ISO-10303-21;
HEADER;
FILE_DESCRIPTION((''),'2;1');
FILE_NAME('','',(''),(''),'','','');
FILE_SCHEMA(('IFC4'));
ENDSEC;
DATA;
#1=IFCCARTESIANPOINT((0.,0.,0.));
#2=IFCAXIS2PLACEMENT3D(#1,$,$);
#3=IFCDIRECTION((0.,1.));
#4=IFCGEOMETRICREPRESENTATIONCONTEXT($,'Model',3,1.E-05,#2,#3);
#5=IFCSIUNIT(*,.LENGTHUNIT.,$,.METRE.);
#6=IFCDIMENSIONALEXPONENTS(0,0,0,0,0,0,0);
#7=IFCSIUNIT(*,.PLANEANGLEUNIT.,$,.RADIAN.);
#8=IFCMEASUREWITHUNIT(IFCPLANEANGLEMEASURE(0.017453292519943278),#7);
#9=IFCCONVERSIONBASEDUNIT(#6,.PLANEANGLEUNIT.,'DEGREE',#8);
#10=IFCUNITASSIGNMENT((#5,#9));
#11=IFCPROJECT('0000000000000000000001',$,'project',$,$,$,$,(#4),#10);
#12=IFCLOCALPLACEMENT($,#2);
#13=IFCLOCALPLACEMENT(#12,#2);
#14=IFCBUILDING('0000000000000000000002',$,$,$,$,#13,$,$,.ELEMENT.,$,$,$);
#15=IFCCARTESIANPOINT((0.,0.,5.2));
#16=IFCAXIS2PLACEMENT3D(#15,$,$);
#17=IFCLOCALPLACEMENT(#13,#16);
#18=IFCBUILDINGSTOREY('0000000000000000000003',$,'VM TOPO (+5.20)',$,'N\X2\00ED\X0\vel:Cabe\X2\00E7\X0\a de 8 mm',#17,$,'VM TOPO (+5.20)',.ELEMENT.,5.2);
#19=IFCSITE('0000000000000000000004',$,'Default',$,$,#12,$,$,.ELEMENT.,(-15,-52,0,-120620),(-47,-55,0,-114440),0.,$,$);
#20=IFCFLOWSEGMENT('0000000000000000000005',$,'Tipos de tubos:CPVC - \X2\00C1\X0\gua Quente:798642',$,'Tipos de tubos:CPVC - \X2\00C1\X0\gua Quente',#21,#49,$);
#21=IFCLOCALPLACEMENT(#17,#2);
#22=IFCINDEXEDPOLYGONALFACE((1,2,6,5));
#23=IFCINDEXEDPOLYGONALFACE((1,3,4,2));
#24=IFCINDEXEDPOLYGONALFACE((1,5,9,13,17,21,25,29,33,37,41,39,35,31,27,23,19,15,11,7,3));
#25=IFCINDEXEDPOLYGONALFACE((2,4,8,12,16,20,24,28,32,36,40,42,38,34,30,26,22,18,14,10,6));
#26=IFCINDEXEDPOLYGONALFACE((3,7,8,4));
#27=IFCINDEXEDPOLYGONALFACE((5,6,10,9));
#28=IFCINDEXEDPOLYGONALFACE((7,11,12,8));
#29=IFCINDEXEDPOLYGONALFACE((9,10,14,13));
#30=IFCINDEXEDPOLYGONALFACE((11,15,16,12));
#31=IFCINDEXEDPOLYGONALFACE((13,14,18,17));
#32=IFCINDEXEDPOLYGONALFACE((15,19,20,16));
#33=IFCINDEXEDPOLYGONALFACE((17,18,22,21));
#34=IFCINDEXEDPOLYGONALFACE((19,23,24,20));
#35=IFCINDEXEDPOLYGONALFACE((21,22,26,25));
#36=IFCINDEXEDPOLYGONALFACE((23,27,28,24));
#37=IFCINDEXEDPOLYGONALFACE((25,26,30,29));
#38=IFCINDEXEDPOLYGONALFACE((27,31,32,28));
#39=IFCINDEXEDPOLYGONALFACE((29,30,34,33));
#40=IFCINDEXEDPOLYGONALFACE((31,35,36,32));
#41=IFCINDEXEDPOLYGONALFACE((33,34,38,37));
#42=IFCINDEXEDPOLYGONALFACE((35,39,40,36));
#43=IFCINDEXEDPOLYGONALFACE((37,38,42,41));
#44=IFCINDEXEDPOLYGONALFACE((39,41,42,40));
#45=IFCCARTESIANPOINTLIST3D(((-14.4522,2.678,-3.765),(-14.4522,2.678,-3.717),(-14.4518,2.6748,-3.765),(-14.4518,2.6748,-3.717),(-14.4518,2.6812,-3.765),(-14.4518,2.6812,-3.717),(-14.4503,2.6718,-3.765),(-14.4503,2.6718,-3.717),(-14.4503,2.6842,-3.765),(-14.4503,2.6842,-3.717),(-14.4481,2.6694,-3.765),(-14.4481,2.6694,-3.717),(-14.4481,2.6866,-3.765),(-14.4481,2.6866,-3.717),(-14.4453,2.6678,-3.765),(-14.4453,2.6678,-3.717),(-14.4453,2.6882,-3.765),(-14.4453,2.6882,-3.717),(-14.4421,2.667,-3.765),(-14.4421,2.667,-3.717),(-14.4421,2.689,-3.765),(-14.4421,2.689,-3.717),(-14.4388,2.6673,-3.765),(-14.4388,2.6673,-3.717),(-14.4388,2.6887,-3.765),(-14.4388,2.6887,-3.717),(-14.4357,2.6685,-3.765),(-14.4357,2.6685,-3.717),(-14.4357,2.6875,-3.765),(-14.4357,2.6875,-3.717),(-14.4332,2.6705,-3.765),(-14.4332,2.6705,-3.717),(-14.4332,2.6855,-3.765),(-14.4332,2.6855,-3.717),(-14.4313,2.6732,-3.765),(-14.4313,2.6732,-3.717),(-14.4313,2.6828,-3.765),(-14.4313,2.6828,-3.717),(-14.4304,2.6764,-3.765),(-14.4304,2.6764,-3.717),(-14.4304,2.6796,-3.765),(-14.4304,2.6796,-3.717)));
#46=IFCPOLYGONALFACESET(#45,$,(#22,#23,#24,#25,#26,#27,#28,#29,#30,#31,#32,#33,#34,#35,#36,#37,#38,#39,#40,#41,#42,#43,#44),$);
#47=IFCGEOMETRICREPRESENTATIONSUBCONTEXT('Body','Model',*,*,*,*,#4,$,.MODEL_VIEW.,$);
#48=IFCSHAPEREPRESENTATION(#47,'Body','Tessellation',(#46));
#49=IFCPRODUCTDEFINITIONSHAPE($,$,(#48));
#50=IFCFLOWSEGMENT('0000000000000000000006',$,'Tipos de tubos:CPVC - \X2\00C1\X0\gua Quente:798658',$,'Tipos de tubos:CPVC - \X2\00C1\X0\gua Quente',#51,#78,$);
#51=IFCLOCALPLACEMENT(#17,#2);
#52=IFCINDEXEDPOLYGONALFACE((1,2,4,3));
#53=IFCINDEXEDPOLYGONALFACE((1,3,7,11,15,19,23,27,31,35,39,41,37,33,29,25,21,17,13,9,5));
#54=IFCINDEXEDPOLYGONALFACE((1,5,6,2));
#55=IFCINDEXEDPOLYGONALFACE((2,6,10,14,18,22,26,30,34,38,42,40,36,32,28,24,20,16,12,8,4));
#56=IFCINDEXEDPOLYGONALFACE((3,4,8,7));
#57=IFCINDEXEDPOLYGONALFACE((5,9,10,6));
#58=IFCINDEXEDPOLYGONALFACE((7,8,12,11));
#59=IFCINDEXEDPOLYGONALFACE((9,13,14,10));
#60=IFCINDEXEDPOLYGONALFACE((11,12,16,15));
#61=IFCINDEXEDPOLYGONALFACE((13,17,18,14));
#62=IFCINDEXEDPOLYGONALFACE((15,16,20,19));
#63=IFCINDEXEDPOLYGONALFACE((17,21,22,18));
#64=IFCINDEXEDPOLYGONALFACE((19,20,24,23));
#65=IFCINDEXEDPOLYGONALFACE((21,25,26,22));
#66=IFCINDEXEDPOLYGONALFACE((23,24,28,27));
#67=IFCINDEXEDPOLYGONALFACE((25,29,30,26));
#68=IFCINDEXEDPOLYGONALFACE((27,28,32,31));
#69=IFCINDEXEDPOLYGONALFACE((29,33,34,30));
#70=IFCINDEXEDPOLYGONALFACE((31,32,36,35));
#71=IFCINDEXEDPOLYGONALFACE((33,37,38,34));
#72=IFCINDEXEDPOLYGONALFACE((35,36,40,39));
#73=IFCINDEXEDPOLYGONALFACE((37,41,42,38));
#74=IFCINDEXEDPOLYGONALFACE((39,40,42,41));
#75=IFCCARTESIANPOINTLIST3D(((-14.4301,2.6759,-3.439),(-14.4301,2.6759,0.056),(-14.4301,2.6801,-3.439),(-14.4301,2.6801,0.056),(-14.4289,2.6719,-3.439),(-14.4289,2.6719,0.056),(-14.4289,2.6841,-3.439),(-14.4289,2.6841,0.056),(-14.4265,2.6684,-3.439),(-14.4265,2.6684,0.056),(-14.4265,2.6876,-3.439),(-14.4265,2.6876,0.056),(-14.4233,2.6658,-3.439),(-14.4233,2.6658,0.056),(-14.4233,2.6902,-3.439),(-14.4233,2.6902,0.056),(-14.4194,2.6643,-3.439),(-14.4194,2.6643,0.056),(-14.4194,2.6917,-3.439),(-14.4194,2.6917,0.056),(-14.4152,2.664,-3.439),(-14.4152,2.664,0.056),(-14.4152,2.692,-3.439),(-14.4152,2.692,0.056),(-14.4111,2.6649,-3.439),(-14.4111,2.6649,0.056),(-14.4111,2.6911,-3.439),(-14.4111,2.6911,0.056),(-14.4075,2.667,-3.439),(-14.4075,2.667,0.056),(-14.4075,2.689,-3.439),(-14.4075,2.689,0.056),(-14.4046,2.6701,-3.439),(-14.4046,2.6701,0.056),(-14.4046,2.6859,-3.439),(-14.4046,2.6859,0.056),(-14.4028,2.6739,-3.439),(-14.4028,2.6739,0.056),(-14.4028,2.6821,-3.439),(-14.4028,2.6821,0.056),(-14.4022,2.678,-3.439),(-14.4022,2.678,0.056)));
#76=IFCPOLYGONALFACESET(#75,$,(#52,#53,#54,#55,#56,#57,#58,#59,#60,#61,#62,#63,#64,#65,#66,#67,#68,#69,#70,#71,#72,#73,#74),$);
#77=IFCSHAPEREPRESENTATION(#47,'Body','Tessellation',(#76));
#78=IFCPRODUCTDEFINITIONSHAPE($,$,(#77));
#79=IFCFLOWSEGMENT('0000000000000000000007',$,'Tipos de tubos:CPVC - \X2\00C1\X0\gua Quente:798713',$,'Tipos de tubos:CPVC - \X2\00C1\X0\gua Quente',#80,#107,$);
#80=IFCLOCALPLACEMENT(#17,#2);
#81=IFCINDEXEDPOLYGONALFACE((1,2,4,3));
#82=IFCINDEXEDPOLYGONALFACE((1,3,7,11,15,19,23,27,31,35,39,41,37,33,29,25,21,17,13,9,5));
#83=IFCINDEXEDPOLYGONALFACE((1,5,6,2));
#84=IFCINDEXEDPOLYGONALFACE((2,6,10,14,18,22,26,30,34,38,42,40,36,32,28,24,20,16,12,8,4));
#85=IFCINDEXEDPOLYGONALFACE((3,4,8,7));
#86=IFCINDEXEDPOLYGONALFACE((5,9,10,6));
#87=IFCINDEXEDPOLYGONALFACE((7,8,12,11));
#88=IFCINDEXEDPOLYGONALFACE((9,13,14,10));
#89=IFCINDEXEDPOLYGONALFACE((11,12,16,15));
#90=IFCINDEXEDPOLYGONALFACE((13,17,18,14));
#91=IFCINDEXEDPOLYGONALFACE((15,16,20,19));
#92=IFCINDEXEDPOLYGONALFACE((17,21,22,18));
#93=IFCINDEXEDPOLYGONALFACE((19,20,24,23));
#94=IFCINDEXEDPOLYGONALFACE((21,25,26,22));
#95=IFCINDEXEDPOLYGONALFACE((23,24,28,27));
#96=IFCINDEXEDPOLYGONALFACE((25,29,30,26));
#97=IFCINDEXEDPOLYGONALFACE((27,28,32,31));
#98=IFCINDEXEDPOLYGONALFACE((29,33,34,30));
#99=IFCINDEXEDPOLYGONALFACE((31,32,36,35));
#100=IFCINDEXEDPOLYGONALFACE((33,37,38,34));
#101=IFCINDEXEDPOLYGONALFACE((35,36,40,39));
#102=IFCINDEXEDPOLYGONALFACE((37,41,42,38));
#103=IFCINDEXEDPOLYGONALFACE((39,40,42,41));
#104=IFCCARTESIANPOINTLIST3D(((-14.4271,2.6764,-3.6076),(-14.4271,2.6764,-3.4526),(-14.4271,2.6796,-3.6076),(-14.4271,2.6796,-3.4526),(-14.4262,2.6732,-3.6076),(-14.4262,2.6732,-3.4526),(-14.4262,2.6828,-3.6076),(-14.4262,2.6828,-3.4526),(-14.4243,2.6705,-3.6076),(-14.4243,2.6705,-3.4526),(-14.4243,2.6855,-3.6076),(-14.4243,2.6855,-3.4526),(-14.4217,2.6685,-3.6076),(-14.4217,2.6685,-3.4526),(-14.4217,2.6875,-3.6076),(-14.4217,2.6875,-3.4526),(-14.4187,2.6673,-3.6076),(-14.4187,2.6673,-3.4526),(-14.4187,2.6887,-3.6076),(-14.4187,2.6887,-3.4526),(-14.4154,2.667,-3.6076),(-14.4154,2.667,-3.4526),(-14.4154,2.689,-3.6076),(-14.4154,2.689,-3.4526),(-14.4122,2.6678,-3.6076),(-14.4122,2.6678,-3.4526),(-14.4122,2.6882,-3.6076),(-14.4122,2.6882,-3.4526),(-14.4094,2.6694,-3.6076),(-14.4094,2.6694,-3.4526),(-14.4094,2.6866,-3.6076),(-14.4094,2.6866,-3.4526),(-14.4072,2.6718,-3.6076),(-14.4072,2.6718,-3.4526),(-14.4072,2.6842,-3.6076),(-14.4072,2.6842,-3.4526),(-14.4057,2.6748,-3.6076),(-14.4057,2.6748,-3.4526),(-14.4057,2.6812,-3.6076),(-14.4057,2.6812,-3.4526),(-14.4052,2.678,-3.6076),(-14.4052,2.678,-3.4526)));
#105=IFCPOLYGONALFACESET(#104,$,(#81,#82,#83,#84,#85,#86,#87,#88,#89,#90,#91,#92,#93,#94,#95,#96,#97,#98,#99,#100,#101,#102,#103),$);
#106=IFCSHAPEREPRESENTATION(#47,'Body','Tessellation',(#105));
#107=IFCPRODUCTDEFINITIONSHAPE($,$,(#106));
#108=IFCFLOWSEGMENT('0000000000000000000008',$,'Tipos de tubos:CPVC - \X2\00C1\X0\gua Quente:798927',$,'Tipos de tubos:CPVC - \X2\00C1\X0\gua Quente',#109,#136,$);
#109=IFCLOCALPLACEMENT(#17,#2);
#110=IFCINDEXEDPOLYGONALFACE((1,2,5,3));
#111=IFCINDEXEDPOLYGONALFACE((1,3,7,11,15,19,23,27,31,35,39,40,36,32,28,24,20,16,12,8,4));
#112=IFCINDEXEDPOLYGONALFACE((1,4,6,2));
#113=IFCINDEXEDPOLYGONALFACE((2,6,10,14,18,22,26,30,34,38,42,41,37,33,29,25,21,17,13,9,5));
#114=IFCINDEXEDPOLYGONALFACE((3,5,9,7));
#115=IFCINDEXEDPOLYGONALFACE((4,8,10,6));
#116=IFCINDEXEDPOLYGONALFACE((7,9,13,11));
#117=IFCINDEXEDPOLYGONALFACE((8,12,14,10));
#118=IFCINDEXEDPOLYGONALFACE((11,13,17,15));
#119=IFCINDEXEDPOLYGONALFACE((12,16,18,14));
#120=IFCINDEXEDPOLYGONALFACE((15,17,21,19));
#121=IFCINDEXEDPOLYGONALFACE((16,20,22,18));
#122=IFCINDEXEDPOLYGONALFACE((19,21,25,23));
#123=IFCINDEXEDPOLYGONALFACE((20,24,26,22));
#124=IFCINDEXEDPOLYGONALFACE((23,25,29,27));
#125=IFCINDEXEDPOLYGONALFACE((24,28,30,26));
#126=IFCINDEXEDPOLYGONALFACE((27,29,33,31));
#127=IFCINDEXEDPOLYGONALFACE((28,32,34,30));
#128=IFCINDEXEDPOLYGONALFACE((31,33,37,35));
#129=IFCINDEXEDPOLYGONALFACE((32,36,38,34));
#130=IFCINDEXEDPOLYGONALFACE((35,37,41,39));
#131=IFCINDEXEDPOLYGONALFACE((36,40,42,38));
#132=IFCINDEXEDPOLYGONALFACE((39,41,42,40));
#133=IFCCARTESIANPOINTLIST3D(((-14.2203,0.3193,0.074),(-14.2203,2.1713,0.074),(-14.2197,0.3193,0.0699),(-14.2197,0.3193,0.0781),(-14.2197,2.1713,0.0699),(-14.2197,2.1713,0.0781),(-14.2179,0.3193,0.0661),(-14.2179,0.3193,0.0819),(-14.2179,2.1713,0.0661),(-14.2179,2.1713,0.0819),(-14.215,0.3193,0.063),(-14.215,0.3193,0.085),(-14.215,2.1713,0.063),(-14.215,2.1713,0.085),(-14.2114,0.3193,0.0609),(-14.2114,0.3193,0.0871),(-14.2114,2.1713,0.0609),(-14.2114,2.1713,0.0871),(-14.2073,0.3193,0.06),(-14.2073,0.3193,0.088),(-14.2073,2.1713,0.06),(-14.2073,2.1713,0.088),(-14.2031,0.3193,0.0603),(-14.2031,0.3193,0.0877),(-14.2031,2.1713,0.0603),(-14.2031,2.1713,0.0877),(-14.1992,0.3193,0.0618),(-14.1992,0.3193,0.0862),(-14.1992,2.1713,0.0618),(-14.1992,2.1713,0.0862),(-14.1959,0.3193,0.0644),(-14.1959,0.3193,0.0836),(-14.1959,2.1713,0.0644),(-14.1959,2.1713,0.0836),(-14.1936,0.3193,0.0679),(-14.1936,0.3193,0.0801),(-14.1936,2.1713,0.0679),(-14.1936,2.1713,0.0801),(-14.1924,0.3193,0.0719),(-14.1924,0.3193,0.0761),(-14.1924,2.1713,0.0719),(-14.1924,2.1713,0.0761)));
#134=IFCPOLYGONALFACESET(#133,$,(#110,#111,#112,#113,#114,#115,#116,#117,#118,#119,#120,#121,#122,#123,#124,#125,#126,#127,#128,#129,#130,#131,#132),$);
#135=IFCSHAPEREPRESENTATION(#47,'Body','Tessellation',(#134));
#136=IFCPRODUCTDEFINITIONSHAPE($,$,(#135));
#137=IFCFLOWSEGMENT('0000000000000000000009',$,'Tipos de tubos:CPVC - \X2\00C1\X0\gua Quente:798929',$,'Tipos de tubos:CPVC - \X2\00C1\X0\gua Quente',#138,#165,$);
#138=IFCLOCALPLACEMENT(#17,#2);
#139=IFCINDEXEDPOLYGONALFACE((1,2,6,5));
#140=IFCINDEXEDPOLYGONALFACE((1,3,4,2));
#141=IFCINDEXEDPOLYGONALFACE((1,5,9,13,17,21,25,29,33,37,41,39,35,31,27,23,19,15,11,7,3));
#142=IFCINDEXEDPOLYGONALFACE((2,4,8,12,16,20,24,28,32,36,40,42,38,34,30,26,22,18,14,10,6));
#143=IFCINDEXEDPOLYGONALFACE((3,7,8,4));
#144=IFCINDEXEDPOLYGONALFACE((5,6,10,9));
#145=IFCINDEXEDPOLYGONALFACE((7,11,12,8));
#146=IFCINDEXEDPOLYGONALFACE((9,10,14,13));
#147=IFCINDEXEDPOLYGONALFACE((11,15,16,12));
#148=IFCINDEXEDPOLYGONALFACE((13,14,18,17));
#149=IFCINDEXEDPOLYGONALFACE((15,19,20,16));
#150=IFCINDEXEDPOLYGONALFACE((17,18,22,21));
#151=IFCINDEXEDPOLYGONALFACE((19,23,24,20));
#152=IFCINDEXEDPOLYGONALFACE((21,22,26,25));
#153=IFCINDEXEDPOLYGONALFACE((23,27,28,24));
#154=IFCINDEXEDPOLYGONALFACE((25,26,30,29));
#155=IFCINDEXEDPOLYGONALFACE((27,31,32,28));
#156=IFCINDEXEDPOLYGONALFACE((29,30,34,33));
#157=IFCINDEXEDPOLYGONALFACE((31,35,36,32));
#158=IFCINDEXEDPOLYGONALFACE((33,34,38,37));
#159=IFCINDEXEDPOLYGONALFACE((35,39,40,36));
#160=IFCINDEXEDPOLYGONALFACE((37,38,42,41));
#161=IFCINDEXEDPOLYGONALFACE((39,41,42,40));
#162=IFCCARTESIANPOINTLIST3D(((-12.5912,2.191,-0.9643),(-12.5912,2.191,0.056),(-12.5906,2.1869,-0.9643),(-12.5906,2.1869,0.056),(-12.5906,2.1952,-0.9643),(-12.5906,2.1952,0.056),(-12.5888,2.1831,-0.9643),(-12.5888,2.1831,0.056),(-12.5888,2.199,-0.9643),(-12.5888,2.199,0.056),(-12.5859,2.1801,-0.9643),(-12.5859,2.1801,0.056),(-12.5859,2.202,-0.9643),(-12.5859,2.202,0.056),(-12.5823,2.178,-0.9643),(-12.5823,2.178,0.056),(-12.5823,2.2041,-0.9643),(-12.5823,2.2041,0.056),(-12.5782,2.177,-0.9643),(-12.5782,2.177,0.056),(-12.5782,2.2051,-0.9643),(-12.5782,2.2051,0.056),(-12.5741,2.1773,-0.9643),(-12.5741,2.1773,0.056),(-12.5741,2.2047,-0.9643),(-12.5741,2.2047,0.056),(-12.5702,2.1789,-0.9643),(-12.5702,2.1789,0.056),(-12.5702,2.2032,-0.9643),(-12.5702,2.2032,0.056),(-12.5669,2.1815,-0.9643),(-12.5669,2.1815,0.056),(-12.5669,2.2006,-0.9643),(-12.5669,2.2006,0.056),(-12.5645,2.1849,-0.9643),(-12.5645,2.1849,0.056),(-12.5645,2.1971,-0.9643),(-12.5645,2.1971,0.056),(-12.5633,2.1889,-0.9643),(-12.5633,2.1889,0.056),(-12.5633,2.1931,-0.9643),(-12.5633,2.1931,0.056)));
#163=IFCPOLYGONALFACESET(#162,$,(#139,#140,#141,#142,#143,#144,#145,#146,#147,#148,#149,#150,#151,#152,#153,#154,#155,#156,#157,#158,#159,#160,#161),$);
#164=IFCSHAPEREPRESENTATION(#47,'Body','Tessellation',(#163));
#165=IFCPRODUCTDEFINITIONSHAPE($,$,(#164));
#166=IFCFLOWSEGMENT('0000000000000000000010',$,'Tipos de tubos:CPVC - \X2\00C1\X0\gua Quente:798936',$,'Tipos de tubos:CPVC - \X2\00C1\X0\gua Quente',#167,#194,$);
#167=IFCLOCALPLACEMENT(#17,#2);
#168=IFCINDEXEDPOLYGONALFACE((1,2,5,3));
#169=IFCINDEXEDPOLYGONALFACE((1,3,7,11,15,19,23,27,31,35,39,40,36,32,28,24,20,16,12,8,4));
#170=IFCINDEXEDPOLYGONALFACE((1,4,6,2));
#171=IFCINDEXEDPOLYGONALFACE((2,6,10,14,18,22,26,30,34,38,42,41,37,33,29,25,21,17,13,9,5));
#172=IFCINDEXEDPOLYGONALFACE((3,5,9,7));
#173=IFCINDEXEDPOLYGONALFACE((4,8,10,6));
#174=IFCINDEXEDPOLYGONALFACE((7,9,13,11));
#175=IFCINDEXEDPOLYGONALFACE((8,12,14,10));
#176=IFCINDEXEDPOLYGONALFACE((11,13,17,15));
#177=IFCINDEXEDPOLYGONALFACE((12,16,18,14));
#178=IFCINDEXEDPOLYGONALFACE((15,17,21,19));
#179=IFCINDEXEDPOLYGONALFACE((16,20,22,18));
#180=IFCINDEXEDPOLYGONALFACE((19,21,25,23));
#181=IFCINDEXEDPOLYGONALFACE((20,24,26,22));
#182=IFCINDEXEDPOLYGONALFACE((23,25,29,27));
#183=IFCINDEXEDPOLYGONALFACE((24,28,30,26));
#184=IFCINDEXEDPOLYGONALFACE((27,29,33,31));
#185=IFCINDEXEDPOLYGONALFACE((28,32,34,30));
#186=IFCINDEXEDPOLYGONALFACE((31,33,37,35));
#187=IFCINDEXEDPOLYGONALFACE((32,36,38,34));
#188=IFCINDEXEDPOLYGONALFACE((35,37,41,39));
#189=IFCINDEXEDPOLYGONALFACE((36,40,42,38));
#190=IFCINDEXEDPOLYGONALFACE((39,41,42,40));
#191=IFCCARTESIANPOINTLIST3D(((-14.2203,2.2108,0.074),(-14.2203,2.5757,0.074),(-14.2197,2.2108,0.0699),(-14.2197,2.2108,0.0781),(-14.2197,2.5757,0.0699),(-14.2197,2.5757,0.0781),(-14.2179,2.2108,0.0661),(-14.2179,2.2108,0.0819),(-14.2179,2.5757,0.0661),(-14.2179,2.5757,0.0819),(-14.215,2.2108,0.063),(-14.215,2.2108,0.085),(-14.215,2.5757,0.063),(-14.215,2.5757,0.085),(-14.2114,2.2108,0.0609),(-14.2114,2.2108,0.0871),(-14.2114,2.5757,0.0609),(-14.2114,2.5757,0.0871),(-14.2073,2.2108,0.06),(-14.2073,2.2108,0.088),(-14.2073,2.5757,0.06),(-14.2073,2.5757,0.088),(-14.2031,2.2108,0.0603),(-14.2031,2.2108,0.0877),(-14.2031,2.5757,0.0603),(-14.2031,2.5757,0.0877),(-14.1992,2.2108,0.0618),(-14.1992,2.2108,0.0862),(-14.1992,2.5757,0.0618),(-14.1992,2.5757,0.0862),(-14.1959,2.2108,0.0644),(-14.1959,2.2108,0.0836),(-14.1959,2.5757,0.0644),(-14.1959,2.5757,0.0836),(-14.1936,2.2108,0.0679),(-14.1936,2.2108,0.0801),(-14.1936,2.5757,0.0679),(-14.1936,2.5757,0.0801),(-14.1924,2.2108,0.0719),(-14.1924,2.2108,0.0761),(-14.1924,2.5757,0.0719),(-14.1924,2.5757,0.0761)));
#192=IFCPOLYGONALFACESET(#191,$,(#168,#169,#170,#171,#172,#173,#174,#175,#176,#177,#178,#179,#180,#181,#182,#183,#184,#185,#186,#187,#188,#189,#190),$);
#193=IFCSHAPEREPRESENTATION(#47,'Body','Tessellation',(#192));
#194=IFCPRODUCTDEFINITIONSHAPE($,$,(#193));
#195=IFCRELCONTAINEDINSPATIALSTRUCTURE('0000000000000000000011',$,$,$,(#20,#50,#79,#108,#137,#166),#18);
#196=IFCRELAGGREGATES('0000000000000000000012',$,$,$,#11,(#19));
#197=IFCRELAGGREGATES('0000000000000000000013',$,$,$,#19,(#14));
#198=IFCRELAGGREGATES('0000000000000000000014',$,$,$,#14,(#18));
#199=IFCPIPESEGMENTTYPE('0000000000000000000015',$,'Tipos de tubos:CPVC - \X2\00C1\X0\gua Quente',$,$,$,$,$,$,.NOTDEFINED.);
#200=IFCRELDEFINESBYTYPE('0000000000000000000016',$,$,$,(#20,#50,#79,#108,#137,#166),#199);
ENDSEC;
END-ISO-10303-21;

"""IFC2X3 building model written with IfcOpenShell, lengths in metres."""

from ifc_helpers import new_model, entity, si_unit, converted_unit, direction, frame, frame_2d, origin, origin_2d_with_axis, place, context, subcontext, project, spatial, circle, extrude, type_object, element, save


model = new_model("IFC2X3")

# Units and contexts
model_context = context("Model", 3, precision=1e-05, world=origin(), true_north=direction((0.0, 1.0)))
body_context = subcontext(model_context, "Body", "Model", "MODEL_VIEW")
ifc_project = project(units=[si_unit("LENGTHUNIT", "METRE"), converted_unit("PLANEANGLEUNIT", "DEGREE", entity("IfcPlaneAngleMeasure", 0.017453292519943278), si_unit("PLANEANGLEUNIT", "RADIAN"), dimensions=[0, 0, 0, 0, 0, 0, 0])], contexts=[model_context])

# Site, building, storey
site_placement = place(None, origin())
site = spatial("IfcSite", under=ifc_project, at=site_placement, Name="Default", CompositionType="ELEMENT", RefLatitude=(-15, -52, 0, -120620), RefLongitude=(-47, -55, 0, -114440), RefElevation=0.0)
building_placement = place(site_placement, origin())
building = spatial("IfcBuilding", under=site, at=building_placement, CompositionType="ELEMENT")
storey_placement = place(building_placement, frame((0.0, 0.0, 5.2)))
storey = spatial("IfcBuildingStorey", under=building, at=storey_placement, Name="VM TOPO (+5.20)", ObjectType="Nível:Cabeça de 8 mm", LongName="VM TOPO (+5.20)", CompositionType="ELEMENT", Elevation=5.2)

# Flow segments
pipe_segment_type_1 = type_object("IfcPipeSegmentType", Name="Tipos de tubos:CPVC - Água Quente", PredefinedType="NOTDEFINED")
flow_segment_1_placement = place(storey_placement, origin())
element("IfcFlowSegment", 1, at=flow_segment_1_placement, inside=storey, type_object=pipe_segment_type_1, Name="Tipos de tubos:CPVC - Água Quente:798642", ObjectType="Tipos de tubos:CPVC - Água Quente", context=body_context, shape_type="SweptSolid", body=[
    extrude(circle(Radius=0.011, at=frame_2d((0.0, 0.0), x_axis=(1.0, 0.0))), frame((-14.4412, 2.678, -3.765), z_axis=(0.0, 0.0, 1.0), x_axis=(-1.0, 0.0, 0.0)), (0.0, 0.0, 1.0), 0.048),
])
flow_segment_2_placement = place(storey_placement, origin())
element("IfcFlowSegment", 2, at=flow_segment_2_placement, inside=storey, type_object=pipe_segment_type_1, Name="Tipos de tubos:CPVC - Água Quente:798658", ObjectType="Tipos de tubos:CPVC - Água Quente", context=body_context, shape_type="SweptSolid", body=[
    extrude(circle(Radius=0.0141, at=origin_2d_with_axis()), frame((-14.4162, 2.678, -3.439)), (0.0, 0.0, 1.0), 3.495),
])
flow_segment_3_placement = place(storey_placement, origin())
element("IfcFlowSegment", 3, at=flow_segment_3_placement, inside=storey, type_object=pipe_segment_type_1, Name="Tipos de tubos:CPVC - Água Quente:798713", ObjectType="Tipos de tubos:CPVC - Água Quente", context=body_context, shape_type="SweptSolid", body=[
    extrude(circle(Radius=0.011, at=frame_2d((0.0, 0.0), x_axis=(1.0, 0.0))), frame((-14.4162, 2.678, -3.6076)), (0.0, 0.0, 1.0), 0.155),
])
flow_segment_4_placement = place(storey_placement, origin())
element("IfcFlowSegment", 4, at=flow_segment_4_placement, inside=storey, type_object=pipe_segment_type_1, Name="Tipos de tubos:CPVC - Água Quente:798927", ObjectType="Tipos de tubos:CPVC - Água Quente", context=body_context, shape_type="SweptSolid", body=[
    extrude(circle(Radius=0.0141, at=frame_2d((0.0, 0.0), x_axis=(1.0, 0.0))), frame((-14.2062, 0.3193, 0.074), z_axis=(0.0, 1.0, 0.0), x_axis=(-1.0, 0.0, 0.0)), (0.0, 0.0, 1.0), 1.852),
])
flow_segment_5_placement = place(storey_placement, origin())
element("IfcFlowSegment", 5, at=flow_segment_5_placement, inside=storey, type_object=pipe_segment_type_1, Name="Tipos de tubos:CPVC - Água Quente:798929", ObjectType="Tipos de tubos:CPVC - Água Quente", context=body_context, shape_type="SweptSolid", body=[
    extrude(circle(Radius=0.0141, at=origin_2d_with_axis()), frame((-12.5772, 2.191, -0.9643), z_axis=(0.0, 0.0, 1.0), x_axis=(-1.0, 0.0, 0.0)), (0.0, 0.0, 1.0), 1.0203),
])
flow_segment_6_placement = place(storey_placement, origin())
element("IfcFlowSegment", 6, at=flow_segment_6_placement, inside=storey, type_object=pipe_segment_type_1, Name="Tipos de tubos:CPVC - Água Quente:798936", ObjectType="Tipos de tubos:CPVC - Água Quente", context=body_context, shape_type="SweptSolid", body=[
    extrude(circle(Radius=0.0141, at=frame_2d((0.0, 0.0), x_axis=(1.0, 0.0))), frame((-14.2062, 2.2108, 0.074), z_axis=(0.0, 1.0, 0.0), x_axis=(-1.0, 0.0, 0.0)), (0.0, 0.0, 1.0), 0.3649),
])

save(model, "model.ifc")
